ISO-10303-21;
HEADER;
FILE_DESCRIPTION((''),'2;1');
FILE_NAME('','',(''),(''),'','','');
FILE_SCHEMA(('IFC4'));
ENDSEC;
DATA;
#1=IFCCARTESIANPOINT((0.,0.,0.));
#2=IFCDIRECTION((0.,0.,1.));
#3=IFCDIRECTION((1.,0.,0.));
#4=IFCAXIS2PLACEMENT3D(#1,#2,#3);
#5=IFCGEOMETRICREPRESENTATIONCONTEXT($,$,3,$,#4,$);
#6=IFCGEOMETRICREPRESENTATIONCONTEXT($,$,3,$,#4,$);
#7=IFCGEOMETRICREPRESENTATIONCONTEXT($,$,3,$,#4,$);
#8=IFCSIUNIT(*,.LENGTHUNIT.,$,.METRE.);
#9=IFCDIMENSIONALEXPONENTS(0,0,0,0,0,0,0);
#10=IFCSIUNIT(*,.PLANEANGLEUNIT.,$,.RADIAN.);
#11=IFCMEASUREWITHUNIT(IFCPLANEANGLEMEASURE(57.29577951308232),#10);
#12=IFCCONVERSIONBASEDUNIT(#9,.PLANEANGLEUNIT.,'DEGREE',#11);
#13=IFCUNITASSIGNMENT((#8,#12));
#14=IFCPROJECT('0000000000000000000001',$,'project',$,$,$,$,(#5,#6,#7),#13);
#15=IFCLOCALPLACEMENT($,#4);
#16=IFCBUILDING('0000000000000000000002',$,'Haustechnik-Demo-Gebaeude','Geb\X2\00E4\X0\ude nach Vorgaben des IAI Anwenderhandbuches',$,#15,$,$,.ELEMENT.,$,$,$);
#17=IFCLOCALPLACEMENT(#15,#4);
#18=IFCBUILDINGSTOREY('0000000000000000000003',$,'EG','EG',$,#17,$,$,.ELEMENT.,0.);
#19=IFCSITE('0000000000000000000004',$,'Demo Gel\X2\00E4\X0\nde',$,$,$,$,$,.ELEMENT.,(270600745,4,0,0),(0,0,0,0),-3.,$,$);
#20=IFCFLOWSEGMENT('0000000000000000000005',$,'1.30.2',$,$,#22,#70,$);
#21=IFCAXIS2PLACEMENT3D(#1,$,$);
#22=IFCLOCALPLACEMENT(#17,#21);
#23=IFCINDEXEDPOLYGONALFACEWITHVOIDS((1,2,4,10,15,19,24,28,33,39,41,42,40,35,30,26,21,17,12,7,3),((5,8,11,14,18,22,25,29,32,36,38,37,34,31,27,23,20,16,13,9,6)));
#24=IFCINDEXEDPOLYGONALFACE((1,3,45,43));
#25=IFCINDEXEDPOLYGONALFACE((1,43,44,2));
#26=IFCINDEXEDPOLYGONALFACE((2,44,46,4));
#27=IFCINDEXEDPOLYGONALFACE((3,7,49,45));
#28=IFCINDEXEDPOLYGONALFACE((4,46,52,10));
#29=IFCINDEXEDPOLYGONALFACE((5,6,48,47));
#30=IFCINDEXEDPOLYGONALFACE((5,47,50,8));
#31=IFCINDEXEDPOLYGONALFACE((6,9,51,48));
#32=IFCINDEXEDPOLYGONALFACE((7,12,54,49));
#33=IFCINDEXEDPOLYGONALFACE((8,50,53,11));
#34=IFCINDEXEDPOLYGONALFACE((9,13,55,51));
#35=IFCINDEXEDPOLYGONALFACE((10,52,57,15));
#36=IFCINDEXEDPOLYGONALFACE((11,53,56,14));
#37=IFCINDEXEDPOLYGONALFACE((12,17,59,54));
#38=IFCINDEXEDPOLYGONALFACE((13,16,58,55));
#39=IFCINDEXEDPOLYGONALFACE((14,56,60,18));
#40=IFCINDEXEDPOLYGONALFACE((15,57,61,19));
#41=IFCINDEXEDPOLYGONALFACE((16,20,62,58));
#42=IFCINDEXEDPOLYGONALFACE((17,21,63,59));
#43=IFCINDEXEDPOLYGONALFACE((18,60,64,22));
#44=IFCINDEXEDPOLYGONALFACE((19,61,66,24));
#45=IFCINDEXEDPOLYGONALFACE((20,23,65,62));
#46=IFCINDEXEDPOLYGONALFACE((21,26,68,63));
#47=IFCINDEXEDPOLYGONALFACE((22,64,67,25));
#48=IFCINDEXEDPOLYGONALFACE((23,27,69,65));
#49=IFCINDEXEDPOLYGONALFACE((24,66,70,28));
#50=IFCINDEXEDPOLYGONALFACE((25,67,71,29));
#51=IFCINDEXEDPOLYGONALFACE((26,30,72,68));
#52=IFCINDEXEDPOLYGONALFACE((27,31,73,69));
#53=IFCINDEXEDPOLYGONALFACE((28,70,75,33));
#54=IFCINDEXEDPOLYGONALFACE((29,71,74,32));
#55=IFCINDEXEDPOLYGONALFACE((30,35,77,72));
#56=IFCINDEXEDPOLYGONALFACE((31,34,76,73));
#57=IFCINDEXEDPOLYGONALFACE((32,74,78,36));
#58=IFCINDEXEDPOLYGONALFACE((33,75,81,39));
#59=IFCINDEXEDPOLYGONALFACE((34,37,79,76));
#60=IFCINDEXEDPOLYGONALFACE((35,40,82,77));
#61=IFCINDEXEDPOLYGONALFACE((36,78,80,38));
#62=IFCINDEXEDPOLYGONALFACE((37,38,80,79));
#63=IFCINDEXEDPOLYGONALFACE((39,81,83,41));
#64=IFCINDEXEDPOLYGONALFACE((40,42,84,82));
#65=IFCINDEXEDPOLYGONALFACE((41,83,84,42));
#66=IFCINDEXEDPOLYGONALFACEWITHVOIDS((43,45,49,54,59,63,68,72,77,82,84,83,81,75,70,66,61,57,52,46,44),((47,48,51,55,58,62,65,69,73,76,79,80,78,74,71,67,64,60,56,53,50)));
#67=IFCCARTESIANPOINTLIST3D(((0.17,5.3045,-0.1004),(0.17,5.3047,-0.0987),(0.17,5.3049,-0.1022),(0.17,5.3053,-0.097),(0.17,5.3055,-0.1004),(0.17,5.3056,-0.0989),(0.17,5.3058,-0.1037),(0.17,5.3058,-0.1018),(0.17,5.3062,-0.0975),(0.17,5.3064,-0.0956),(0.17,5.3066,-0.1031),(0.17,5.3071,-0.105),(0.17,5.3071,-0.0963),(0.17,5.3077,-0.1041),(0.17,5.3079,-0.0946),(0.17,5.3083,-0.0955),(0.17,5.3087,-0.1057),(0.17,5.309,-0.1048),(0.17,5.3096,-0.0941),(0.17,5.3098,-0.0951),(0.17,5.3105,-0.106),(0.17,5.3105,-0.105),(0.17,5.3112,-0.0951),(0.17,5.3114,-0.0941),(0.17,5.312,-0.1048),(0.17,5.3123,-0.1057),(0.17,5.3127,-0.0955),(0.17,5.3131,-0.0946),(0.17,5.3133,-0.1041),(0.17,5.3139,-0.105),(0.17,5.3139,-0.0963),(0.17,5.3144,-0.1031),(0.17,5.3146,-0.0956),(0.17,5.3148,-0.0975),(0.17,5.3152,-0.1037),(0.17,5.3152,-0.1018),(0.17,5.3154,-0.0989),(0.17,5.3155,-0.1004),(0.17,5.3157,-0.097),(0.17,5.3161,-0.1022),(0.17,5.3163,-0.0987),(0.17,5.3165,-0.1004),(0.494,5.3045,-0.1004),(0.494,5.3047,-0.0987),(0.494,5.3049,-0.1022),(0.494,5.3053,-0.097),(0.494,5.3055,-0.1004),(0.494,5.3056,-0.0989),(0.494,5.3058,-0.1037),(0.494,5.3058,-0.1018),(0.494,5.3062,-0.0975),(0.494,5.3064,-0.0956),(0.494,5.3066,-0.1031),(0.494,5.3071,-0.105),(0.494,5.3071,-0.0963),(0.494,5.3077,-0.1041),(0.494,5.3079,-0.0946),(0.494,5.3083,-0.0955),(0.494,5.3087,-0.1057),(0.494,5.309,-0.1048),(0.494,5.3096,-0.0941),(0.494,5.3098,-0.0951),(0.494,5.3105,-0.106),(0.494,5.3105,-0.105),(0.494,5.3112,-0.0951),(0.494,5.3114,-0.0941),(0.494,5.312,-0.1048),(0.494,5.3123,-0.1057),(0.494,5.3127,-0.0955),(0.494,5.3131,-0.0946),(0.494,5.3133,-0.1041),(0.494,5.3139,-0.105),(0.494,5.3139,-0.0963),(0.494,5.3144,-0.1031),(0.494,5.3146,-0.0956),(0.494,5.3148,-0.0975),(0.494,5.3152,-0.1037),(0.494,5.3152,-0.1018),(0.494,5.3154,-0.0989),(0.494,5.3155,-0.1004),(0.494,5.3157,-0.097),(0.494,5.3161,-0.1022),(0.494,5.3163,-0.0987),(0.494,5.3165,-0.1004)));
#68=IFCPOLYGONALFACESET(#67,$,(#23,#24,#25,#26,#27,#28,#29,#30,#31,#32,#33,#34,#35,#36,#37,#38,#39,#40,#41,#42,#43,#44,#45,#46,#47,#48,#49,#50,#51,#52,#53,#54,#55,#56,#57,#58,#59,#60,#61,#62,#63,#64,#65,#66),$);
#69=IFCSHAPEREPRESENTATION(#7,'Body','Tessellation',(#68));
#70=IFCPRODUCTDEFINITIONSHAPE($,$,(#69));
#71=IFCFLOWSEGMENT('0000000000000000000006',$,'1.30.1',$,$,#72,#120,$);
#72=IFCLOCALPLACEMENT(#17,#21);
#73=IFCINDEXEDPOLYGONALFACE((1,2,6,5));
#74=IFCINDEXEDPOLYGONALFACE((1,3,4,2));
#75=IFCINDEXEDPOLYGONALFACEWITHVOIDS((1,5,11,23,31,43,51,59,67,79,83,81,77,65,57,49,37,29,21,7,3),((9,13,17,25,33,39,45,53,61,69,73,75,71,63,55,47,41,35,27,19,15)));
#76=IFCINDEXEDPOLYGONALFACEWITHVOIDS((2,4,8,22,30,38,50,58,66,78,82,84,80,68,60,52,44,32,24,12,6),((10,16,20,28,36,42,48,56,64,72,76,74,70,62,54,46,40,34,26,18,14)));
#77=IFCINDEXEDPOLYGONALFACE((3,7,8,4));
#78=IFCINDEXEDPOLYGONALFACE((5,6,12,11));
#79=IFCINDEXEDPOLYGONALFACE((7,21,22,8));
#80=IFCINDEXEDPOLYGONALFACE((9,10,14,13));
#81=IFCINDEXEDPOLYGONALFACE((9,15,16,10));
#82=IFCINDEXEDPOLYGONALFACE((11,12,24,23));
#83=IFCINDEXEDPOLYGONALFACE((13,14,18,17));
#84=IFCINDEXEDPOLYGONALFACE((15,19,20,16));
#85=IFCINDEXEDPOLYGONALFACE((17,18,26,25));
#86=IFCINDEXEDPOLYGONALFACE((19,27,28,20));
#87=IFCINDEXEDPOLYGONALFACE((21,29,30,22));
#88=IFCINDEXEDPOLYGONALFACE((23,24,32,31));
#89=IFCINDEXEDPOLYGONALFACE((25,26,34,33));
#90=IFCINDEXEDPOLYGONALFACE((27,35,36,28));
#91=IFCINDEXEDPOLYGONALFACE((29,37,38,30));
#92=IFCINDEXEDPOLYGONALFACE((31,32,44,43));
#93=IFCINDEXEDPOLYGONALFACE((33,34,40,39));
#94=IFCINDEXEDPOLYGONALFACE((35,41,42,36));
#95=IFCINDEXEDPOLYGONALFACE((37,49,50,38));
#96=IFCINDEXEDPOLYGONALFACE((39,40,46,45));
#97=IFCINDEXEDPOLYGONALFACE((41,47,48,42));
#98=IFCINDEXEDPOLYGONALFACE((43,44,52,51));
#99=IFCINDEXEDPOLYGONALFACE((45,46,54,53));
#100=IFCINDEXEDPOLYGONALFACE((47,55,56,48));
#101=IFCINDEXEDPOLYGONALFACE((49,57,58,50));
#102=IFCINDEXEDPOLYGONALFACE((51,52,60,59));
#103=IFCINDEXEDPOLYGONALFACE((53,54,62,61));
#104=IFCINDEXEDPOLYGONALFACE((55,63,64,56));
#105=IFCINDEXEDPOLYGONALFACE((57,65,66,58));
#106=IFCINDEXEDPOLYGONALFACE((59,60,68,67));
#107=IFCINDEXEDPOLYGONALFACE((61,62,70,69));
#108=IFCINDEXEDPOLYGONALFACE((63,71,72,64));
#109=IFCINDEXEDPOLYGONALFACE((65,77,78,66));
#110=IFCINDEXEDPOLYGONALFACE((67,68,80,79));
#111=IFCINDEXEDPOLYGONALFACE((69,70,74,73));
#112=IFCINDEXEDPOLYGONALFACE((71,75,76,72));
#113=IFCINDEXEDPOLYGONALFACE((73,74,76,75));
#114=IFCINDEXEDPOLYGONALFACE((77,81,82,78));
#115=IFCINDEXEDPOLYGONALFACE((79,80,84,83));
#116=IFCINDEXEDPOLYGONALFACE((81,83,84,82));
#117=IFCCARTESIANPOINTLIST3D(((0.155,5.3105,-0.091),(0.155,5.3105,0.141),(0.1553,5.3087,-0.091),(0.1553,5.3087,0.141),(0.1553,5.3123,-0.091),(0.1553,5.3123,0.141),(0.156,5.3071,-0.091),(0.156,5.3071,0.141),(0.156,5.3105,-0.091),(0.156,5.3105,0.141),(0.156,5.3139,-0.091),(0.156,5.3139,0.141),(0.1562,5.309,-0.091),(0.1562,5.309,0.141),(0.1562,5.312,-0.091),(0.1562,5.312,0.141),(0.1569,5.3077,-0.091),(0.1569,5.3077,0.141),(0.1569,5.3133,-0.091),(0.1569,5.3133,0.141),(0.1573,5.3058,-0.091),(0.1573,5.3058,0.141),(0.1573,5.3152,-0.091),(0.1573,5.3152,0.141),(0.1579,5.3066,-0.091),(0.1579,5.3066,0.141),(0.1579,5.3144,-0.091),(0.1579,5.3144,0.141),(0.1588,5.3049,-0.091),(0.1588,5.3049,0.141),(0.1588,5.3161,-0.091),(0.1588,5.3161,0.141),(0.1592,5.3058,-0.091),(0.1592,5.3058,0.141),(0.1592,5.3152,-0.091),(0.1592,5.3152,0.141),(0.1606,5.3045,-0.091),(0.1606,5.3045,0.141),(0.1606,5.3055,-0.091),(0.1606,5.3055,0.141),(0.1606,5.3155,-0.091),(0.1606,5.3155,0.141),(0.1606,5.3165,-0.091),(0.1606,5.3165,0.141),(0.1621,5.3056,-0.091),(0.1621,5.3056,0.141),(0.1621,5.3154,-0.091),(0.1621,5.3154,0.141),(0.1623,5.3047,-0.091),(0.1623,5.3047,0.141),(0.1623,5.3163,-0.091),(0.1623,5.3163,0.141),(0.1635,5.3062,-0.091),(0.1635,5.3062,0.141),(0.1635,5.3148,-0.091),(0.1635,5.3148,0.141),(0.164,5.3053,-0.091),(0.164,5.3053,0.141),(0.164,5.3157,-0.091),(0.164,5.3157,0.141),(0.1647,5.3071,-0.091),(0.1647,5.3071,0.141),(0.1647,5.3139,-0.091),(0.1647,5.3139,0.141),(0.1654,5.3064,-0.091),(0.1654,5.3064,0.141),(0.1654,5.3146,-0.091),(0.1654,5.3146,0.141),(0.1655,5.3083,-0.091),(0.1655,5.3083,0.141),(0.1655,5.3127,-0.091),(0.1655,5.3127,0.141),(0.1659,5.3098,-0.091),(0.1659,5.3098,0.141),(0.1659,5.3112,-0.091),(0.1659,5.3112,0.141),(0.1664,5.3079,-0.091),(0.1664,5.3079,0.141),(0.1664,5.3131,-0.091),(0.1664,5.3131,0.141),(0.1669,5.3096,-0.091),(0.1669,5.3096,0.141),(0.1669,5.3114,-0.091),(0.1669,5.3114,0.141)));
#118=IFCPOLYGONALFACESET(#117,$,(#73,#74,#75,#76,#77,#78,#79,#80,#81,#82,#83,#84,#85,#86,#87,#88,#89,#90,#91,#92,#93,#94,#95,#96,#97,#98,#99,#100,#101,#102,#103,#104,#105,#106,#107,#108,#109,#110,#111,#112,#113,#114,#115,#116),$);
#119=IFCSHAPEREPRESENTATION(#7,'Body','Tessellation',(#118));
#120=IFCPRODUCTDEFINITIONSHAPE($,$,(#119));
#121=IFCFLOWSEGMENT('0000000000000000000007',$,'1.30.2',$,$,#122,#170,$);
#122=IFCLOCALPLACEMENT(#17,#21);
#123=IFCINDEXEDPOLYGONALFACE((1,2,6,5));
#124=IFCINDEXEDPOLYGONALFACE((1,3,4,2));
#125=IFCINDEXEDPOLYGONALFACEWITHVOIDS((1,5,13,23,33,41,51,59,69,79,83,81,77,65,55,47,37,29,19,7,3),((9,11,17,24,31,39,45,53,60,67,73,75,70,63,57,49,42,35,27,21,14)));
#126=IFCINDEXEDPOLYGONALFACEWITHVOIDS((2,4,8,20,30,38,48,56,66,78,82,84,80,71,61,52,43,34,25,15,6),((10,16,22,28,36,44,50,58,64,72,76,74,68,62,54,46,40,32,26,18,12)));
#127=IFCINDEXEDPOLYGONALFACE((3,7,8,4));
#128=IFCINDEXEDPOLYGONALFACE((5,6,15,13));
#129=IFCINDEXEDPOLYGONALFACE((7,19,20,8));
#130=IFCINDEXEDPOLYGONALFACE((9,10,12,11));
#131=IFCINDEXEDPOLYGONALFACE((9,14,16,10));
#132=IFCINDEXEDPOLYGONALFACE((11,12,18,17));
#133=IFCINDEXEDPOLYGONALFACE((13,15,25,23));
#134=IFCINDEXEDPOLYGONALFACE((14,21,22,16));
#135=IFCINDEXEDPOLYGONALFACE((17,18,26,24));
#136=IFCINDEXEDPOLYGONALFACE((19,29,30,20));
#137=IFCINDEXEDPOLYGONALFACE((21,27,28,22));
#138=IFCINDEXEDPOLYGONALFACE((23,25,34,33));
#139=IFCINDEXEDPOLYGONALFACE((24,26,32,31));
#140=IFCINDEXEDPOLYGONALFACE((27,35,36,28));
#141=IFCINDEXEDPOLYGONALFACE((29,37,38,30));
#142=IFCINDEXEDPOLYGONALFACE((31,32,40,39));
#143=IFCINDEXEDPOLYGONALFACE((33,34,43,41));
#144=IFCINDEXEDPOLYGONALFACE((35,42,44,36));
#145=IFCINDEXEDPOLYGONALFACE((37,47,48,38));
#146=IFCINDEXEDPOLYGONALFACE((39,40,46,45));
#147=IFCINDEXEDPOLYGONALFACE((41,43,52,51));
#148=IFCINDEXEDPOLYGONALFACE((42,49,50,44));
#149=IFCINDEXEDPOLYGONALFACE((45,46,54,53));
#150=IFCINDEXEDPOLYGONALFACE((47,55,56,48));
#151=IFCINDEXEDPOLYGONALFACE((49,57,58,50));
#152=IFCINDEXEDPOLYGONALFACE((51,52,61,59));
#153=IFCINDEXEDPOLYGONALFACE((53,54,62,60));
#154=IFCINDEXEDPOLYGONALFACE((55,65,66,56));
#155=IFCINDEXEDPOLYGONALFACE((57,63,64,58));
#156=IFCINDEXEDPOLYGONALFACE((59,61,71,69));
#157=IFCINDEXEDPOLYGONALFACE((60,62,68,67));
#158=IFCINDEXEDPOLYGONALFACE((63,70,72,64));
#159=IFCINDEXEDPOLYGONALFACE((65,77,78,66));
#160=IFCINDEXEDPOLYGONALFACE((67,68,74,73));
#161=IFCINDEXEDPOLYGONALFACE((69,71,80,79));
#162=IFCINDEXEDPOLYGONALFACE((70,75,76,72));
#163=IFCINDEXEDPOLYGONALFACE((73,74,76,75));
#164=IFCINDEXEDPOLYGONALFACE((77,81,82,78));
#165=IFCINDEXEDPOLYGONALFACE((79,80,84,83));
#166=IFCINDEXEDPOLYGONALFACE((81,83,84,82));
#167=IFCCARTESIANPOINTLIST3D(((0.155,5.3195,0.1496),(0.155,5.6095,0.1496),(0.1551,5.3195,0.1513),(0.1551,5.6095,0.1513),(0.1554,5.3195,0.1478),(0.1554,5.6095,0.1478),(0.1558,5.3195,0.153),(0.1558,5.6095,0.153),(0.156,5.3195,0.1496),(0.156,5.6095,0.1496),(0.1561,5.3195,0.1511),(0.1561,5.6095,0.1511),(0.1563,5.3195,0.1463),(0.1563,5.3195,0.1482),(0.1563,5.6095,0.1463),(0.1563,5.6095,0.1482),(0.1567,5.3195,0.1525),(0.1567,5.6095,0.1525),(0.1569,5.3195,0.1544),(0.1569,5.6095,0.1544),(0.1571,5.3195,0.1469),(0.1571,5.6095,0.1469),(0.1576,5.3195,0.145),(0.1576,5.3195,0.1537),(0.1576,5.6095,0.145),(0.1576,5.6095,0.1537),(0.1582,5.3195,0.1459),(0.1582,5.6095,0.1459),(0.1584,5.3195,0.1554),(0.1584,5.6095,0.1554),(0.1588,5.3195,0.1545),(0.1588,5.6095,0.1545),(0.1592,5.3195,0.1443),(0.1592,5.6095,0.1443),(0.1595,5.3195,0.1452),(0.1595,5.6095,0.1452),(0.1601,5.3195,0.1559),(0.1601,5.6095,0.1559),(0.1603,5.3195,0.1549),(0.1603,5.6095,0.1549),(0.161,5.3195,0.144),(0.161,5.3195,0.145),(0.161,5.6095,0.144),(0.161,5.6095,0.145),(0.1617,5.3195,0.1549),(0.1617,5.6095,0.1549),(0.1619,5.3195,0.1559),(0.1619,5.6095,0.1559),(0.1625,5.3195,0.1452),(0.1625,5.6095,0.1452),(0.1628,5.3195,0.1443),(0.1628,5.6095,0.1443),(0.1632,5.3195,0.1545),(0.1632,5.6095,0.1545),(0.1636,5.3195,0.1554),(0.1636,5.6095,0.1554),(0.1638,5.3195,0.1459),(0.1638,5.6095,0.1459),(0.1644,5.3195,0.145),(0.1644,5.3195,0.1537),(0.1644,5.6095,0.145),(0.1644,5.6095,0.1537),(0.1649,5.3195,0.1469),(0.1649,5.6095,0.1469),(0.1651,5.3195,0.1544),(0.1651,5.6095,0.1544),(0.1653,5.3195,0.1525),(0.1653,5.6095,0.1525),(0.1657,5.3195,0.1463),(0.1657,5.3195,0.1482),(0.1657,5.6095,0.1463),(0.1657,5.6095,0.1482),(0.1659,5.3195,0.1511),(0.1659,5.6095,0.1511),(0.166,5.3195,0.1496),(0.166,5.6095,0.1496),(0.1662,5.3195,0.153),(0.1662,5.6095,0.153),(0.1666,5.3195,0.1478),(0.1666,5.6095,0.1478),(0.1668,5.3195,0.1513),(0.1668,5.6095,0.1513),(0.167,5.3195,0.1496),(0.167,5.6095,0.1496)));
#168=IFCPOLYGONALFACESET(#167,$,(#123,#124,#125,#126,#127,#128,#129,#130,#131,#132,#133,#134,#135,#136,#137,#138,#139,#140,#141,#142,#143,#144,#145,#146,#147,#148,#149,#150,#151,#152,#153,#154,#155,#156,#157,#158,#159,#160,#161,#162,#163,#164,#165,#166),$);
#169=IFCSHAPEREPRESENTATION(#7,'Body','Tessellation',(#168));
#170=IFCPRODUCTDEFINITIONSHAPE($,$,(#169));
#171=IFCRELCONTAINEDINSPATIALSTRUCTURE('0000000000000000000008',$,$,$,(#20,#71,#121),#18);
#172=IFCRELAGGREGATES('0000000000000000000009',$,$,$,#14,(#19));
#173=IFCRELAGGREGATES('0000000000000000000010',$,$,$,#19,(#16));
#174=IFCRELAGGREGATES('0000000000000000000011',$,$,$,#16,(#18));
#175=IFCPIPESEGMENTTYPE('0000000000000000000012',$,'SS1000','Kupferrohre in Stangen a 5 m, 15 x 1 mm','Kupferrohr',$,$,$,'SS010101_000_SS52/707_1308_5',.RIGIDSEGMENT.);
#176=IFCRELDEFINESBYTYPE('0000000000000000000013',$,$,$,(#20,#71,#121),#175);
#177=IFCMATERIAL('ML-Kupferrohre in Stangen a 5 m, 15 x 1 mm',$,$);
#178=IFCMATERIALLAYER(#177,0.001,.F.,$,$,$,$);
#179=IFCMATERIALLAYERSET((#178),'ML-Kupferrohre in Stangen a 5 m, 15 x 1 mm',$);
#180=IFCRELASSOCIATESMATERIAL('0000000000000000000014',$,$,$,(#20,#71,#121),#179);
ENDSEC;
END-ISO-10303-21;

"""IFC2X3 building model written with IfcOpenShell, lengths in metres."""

from ifc_helpers import new_model, entity, si_unit, converted_unit, frame, origin_with_axes, origin_2d_with_axis, place, context, project, spatial, hollow_circle, extrude, material, layer, layer_set, layer_usage, type_object, element, save


model = new_model("IFC2X3")

# Units and contexts
context_of_model_1 = context(None, 3, world=origin_with_axes())
context_of_model_2 = context(None, 3, world=origin_with_axes())
context_of_model_3 = context(None, 3, world=origin_with_axes())
ifc_project = project(units=[si_unit("LENGTHUNIT", "METRE"), converted_unit("PLANEANGLEUNIT", "DEGREE", entity("IfcPlaneAngleMeasure", 57.29577951308232), si_unit("PLANEANGLEUNIT", "RADIAN"), dimensions=[0, 0, 0, 0, 0, 0, 0])], contexts=[context_of_model_1, context_of_model_2, context_of_model_3])

# Site, building, storey
site = spatial("IfcSite", under=ifc_project, Name="Demo Gelände", CompositionType="ELEMENT", RefLatitude=(270600745, 4, 0, 0), RefLongitude=(0, 0, 0, 0), RefElevation=-3.0)
building_placement = place(None, origin_with_axes())
building = spatial("IfcBuilding", under=site, at=building_placement, Name="Haustechnik-Demo-Gebaeude", Description="Gebäude nach Vorgaben des IAI Anwenderhandbuches", CompositionType="ELEMENT")
storey_placement = place(building_placement, origin_with_axes())
storey = spatial("IfcBuildingStorey", under=building, at=storey_placement, Name="EG", Description="EG", CompositionType="ELEMENT", Elevation=0.0)

# Flow segments
ifc_material = material(Name="ML-Kupferrohre in Stangen a 5 m, 15 x 1 mm")
ifc_layer = layer(ifc_material, 0.001, ventilated=False)
ifc_layer_set = layer_set([ifc_layer], Name="ML-Kupferrohre in Stangen a 5 m, 15 x 1 mm")
ifc_layer_usage = layer_usage(ifc_layer_set, "AXIS2", "POSITIVE", 0.0)
pipe_segment_type_1 = type_object("IfcPipeSegmentType", Name="SS1000", Description="Kupferrohre in Stangen a 5 m, 15 x 1 mm", ApplicableOccurrence="Kupferrohr", ElementType="SS010101_000_SS52/707_1308_5", PredefinedType="RIGIDSEGMENT")
flow_segment_1_placement = place(storey_placement, frame((0.494, 5.3105, -0.1), z_axis=(-1.0, 0.0, 0.0), x_axis=(0.0, 0.0, -1.0)))
element("IfcFlowSegment", 1, at=flow_segment_1_placement, inside=storey, type_object=pipe_segment_type_1, material=ifc_layer_usage, Name="1.30.2", context=context_of_model_3, shape_type="SweptSolid", body=[
    extrude(hollow_circle(Radius=0.006, WallThickness=0.001, at=origin_2d_with_axis()), origin_with_axes(), (0.0, 0.0, 1.0), 0.324),
])
flow_segment_2_placement = place(storey_placement, frame((0.161, 5.3105, -0.091), z_axis=(0.0, 0.0, 1.0), x_axis=(-1.0, 0.0, 0.0)))
element("IfcFlowSegment", 2, at=flow_segment_2_placement, inside=storey, type_object=pipe_segment_type_1, material=ifc_layer_usage, Name="1.30.1", context=context_of_model_3, shape_type="SweptSolid", body=[
    extrude(hollow_circle(Radius=0.006, WallThickness=0.001, at=origin_2d_with_axis()), origin_with_axes(), (0.0, 0.0, 1.0), 0.232),
])
flow_segment_3_placement = place(storey_placement, frame((0.161, 5.3195, 0.15), z_axis=(0.0, 1.0, 0.0), x_axis=(0.0, 0.0, -1.0)))
element("IfcFlowSegment", 3, at=flow_segment_3_placement, inside=storey, type_object=pipe_segment_type_1, material=ifc_layer_usage, Name="1.30.2", context=context_of_model_3, shape_type="SweptSolid", body=[
    extrude(hollow_circle(Radius=0.006, WallThickness=0.001, at=origin_2d_with_axis()), origin_with_axes(), (0.0, 0.0, 1.0), 0.29),
])

save(model, "model.ifc")
